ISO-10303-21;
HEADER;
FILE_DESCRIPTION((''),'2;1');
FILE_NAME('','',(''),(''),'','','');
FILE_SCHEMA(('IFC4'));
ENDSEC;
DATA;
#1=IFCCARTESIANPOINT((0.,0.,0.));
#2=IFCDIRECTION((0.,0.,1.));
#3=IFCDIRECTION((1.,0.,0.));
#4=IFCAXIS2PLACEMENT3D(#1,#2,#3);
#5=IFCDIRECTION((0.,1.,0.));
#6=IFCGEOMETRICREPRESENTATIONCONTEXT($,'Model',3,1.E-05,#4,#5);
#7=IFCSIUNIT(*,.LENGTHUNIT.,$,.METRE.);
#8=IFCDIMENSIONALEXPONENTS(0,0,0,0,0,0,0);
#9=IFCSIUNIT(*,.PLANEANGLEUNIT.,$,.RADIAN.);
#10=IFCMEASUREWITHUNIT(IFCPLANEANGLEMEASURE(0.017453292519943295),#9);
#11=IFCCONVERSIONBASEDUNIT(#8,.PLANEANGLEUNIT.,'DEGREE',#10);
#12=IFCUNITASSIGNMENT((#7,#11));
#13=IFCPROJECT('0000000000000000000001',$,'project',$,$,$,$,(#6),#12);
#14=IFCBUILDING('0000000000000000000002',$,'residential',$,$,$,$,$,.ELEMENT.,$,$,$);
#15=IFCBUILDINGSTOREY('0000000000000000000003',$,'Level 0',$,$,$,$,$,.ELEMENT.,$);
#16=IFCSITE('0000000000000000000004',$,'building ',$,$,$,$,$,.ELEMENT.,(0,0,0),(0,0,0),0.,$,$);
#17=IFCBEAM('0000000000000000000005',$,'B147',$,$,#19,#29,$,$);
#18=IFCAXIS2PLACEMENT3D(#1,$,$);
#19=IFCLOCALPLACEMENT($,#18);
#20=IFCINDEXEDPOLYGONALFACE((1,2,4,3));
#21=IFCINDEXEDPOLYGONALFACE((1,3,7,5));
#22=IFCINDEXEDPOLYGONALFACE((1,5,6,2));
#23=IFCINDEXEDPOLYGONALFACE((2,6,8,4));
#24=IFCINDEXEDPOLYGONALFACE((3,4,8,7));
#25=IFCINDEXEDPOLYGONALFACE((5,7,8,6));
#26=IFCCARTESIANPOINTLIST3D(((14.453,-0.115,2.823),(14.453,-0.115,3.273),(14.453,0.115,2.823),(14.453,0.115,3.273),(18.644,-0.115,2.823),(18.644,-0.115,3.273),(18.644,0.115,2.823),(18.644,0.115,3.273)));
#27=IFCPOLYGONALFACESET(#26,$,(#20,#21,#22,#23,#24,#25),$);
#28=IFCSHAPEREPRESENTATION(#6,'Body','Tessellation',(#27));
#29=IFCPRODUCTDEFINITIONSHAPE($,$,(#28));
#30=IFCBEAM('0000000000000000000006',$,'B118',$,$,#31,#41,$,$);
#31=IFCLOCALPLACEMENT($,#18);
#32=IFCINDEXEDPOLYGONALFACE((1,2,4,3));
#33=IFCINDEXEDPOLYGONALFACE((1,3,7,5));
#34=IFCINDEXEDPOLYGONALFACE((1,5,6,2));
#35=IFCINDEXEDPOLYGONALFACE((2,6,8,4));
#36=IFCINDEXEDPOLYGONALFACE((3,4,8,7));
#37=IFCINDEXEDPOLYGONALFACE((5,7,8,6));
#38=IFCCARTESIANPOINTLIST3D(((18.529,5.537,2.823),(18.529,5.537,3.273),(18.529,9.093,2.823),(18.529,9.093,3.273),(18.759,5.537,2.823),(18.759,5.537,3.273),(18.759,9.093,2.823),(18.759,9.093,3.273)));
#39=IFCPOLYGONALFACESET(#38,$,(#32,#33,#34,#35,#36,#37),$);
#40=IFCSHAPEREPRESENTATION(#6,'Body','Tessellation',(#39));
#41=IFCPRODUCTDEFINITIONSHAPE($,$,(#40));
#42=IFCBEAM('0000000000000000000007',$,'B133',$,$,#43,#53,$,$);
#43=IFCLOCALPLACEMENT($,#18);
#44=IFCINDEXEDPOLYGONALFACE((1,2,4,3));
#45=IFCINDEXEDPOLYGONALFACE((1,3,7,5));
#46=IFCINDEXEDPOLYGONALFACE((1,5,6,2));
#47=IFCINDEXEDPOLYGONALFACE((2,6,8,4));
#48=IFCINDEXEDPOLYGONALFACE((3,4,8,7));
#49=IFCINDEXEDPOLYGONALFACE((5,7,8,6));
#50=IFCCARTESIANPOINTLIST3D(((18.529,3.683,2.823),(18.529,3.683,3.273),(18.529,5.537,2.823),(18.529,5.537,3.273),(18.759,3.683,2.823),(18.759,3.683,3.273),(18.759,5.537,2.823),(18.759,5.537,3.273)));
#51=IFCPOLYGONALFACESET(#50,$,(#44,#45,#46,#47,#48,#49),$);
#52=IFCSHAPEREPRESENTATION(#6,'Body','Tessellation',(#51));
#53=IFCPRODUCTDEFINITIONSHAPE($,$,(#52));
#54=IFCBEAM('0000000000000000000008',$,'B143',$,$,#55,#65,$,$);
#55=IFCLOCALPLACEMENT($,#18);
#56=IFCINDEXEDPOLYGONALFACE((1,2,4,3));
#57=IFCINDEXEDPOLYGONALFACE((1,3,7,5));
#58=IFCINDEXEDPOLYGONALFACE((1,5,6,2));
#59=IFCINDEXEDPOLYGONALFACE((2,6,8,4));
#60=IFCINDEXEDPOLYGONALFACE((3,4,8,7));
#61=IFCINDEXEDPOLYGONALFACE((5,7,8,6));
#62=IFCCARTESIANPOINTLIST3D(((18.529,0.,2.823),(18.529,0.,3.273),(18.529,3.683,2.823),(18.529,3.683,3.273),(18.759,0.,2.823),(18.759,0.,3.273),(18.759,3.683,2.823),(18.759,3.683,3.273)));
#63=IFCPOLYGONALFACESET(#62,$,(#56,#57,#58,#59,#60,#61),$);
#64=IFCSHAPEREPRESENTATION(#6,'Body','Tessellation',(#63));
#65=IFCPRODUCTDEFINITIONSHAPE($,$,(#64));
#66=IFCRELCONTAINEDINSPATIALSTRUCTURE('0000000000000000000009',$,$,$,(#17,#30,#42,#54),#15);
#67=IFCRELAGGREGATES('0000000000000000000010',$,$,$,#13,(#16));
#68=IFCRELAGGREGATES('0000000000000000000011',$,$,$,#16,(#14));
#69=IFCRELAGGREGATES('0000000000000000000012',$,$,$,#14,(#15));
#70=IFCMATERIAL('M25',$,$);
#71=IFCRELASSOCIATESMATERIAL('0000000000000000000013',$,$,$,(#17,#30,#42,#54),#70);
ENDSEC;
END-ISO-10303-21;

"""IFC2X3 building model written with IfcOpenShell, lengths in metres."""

from ifc_helpers import new_model, entity, si_unit, converted_unit, direction, frame, frame_2d, origin_with_axes, place, context, project, spatial, rectangle, extrude, material, element, save


model = new_model("IFC2X3")

# Units and contexts
model_context = context("Model", 3, precision=1e-05, world=origin_with_axes(), true_north=direction((0.0, 1.0, 0.0)))
ifc_project = project(units=[si_unit("LENGTHUNIT", "METRE"), converted_unit("PLANEANGLEUNIT", "DEGREE", entity("IfcPlaneAngleMeasure", 0.017453292519943295), si_unit("PLANEANGLEUNIT", "RADIAN"), dimensions=[0, 0, 0, 0, 0, 0, 0])], contexts=[model_context])

# Site, building, storey
site = spatial("IfcSite", under=ifc_project, Name="building ", CompositionType="ELEMENT", RefLatitude=(0, 0, 0), RefLongitude=(0, 0, 0), RefElevation=0.0)
building = spatial("IfcBuilding", under=site, Name="residential", CompositionType="ELEMENT")
storey = spatial("IfcBuildingStorey", under=building, Name="Level 0", CompositionType="ELEMENT")

# Shared definitions
ifc_material = material(Name="M25")
placement = place(None, origin_with_axes())

# Beams
element("IfcBeam", 1, at=placement, inside=storey, material=ifc_material, Name="B147", context=model_context, shape_type="SweptSolid", body=[
    extrude(rectangle(XDim=0.23, YDim=0.45, at=frame_2d((0.0, 0.0), x_axis=(0.0, 1.0, 0.0))), frame((18.644, 0.0, 3.048), z_axis=(-1.0, 0.0, 0.0), x_axis=(0.0, 0.0, -1.0)), (0.0, 0.0, 1.0), 4.191),
])
element("IfcBeam", 2, at=placement, inside=storey, material=ifc_material, Name="B118", context=model_context, shape_type="SweptSolid", body=[
    extrude(rectangle(XDim=0.23, YDim=0.45, at=frame_2d((0.0, 0.0), x_axis=(0.0, 1.0, 0.0))), frame((18.644, 9.093, 3.048), z_axis=(0.0, -1.0, 0.0), x_axis=(0.0, 0.0, -1.0)), (0.0, 0.0, 1.0), 3.556),
])
element("IfcBeam", 3, at=placement, inside=storey, material=ifc_material, Name="B133", context=model_context, shape_type="SweptSolid", body=[
    extrude(rectangle(XDim=0.23, YDim=0.45, at=frame_2d((0.0, 0.0), x_axis=(0.0, 1.0, 0.0))), frame((18.644, 3.683, 3.048), z_axis=(0.0, 1.0, 0.0), x_axis=(0.0, 0.0, -1.0)), (0.0, 0.0, 1.0), 1.854),
])
element("IfcBeam", 4, at=placement, inside=storey, material=ifc_material, Name="B143", context=model_context, shape_type="SweptSolid", body=[
    extrude(rectangle(XDim=0.23, YDim=0.45, at=frame_2d((0.0, 0.0), x_axis=(0.0, 1.0, 0.0))), frame((18.644, 0.0, 3.048), z_axis=(0.0, 1.0, 0.0), x_axis=(0.0, 0.0, -1.0)), (0.0, 0.0, 1.0), 3.683),
])

save(model, "model.ifc")
